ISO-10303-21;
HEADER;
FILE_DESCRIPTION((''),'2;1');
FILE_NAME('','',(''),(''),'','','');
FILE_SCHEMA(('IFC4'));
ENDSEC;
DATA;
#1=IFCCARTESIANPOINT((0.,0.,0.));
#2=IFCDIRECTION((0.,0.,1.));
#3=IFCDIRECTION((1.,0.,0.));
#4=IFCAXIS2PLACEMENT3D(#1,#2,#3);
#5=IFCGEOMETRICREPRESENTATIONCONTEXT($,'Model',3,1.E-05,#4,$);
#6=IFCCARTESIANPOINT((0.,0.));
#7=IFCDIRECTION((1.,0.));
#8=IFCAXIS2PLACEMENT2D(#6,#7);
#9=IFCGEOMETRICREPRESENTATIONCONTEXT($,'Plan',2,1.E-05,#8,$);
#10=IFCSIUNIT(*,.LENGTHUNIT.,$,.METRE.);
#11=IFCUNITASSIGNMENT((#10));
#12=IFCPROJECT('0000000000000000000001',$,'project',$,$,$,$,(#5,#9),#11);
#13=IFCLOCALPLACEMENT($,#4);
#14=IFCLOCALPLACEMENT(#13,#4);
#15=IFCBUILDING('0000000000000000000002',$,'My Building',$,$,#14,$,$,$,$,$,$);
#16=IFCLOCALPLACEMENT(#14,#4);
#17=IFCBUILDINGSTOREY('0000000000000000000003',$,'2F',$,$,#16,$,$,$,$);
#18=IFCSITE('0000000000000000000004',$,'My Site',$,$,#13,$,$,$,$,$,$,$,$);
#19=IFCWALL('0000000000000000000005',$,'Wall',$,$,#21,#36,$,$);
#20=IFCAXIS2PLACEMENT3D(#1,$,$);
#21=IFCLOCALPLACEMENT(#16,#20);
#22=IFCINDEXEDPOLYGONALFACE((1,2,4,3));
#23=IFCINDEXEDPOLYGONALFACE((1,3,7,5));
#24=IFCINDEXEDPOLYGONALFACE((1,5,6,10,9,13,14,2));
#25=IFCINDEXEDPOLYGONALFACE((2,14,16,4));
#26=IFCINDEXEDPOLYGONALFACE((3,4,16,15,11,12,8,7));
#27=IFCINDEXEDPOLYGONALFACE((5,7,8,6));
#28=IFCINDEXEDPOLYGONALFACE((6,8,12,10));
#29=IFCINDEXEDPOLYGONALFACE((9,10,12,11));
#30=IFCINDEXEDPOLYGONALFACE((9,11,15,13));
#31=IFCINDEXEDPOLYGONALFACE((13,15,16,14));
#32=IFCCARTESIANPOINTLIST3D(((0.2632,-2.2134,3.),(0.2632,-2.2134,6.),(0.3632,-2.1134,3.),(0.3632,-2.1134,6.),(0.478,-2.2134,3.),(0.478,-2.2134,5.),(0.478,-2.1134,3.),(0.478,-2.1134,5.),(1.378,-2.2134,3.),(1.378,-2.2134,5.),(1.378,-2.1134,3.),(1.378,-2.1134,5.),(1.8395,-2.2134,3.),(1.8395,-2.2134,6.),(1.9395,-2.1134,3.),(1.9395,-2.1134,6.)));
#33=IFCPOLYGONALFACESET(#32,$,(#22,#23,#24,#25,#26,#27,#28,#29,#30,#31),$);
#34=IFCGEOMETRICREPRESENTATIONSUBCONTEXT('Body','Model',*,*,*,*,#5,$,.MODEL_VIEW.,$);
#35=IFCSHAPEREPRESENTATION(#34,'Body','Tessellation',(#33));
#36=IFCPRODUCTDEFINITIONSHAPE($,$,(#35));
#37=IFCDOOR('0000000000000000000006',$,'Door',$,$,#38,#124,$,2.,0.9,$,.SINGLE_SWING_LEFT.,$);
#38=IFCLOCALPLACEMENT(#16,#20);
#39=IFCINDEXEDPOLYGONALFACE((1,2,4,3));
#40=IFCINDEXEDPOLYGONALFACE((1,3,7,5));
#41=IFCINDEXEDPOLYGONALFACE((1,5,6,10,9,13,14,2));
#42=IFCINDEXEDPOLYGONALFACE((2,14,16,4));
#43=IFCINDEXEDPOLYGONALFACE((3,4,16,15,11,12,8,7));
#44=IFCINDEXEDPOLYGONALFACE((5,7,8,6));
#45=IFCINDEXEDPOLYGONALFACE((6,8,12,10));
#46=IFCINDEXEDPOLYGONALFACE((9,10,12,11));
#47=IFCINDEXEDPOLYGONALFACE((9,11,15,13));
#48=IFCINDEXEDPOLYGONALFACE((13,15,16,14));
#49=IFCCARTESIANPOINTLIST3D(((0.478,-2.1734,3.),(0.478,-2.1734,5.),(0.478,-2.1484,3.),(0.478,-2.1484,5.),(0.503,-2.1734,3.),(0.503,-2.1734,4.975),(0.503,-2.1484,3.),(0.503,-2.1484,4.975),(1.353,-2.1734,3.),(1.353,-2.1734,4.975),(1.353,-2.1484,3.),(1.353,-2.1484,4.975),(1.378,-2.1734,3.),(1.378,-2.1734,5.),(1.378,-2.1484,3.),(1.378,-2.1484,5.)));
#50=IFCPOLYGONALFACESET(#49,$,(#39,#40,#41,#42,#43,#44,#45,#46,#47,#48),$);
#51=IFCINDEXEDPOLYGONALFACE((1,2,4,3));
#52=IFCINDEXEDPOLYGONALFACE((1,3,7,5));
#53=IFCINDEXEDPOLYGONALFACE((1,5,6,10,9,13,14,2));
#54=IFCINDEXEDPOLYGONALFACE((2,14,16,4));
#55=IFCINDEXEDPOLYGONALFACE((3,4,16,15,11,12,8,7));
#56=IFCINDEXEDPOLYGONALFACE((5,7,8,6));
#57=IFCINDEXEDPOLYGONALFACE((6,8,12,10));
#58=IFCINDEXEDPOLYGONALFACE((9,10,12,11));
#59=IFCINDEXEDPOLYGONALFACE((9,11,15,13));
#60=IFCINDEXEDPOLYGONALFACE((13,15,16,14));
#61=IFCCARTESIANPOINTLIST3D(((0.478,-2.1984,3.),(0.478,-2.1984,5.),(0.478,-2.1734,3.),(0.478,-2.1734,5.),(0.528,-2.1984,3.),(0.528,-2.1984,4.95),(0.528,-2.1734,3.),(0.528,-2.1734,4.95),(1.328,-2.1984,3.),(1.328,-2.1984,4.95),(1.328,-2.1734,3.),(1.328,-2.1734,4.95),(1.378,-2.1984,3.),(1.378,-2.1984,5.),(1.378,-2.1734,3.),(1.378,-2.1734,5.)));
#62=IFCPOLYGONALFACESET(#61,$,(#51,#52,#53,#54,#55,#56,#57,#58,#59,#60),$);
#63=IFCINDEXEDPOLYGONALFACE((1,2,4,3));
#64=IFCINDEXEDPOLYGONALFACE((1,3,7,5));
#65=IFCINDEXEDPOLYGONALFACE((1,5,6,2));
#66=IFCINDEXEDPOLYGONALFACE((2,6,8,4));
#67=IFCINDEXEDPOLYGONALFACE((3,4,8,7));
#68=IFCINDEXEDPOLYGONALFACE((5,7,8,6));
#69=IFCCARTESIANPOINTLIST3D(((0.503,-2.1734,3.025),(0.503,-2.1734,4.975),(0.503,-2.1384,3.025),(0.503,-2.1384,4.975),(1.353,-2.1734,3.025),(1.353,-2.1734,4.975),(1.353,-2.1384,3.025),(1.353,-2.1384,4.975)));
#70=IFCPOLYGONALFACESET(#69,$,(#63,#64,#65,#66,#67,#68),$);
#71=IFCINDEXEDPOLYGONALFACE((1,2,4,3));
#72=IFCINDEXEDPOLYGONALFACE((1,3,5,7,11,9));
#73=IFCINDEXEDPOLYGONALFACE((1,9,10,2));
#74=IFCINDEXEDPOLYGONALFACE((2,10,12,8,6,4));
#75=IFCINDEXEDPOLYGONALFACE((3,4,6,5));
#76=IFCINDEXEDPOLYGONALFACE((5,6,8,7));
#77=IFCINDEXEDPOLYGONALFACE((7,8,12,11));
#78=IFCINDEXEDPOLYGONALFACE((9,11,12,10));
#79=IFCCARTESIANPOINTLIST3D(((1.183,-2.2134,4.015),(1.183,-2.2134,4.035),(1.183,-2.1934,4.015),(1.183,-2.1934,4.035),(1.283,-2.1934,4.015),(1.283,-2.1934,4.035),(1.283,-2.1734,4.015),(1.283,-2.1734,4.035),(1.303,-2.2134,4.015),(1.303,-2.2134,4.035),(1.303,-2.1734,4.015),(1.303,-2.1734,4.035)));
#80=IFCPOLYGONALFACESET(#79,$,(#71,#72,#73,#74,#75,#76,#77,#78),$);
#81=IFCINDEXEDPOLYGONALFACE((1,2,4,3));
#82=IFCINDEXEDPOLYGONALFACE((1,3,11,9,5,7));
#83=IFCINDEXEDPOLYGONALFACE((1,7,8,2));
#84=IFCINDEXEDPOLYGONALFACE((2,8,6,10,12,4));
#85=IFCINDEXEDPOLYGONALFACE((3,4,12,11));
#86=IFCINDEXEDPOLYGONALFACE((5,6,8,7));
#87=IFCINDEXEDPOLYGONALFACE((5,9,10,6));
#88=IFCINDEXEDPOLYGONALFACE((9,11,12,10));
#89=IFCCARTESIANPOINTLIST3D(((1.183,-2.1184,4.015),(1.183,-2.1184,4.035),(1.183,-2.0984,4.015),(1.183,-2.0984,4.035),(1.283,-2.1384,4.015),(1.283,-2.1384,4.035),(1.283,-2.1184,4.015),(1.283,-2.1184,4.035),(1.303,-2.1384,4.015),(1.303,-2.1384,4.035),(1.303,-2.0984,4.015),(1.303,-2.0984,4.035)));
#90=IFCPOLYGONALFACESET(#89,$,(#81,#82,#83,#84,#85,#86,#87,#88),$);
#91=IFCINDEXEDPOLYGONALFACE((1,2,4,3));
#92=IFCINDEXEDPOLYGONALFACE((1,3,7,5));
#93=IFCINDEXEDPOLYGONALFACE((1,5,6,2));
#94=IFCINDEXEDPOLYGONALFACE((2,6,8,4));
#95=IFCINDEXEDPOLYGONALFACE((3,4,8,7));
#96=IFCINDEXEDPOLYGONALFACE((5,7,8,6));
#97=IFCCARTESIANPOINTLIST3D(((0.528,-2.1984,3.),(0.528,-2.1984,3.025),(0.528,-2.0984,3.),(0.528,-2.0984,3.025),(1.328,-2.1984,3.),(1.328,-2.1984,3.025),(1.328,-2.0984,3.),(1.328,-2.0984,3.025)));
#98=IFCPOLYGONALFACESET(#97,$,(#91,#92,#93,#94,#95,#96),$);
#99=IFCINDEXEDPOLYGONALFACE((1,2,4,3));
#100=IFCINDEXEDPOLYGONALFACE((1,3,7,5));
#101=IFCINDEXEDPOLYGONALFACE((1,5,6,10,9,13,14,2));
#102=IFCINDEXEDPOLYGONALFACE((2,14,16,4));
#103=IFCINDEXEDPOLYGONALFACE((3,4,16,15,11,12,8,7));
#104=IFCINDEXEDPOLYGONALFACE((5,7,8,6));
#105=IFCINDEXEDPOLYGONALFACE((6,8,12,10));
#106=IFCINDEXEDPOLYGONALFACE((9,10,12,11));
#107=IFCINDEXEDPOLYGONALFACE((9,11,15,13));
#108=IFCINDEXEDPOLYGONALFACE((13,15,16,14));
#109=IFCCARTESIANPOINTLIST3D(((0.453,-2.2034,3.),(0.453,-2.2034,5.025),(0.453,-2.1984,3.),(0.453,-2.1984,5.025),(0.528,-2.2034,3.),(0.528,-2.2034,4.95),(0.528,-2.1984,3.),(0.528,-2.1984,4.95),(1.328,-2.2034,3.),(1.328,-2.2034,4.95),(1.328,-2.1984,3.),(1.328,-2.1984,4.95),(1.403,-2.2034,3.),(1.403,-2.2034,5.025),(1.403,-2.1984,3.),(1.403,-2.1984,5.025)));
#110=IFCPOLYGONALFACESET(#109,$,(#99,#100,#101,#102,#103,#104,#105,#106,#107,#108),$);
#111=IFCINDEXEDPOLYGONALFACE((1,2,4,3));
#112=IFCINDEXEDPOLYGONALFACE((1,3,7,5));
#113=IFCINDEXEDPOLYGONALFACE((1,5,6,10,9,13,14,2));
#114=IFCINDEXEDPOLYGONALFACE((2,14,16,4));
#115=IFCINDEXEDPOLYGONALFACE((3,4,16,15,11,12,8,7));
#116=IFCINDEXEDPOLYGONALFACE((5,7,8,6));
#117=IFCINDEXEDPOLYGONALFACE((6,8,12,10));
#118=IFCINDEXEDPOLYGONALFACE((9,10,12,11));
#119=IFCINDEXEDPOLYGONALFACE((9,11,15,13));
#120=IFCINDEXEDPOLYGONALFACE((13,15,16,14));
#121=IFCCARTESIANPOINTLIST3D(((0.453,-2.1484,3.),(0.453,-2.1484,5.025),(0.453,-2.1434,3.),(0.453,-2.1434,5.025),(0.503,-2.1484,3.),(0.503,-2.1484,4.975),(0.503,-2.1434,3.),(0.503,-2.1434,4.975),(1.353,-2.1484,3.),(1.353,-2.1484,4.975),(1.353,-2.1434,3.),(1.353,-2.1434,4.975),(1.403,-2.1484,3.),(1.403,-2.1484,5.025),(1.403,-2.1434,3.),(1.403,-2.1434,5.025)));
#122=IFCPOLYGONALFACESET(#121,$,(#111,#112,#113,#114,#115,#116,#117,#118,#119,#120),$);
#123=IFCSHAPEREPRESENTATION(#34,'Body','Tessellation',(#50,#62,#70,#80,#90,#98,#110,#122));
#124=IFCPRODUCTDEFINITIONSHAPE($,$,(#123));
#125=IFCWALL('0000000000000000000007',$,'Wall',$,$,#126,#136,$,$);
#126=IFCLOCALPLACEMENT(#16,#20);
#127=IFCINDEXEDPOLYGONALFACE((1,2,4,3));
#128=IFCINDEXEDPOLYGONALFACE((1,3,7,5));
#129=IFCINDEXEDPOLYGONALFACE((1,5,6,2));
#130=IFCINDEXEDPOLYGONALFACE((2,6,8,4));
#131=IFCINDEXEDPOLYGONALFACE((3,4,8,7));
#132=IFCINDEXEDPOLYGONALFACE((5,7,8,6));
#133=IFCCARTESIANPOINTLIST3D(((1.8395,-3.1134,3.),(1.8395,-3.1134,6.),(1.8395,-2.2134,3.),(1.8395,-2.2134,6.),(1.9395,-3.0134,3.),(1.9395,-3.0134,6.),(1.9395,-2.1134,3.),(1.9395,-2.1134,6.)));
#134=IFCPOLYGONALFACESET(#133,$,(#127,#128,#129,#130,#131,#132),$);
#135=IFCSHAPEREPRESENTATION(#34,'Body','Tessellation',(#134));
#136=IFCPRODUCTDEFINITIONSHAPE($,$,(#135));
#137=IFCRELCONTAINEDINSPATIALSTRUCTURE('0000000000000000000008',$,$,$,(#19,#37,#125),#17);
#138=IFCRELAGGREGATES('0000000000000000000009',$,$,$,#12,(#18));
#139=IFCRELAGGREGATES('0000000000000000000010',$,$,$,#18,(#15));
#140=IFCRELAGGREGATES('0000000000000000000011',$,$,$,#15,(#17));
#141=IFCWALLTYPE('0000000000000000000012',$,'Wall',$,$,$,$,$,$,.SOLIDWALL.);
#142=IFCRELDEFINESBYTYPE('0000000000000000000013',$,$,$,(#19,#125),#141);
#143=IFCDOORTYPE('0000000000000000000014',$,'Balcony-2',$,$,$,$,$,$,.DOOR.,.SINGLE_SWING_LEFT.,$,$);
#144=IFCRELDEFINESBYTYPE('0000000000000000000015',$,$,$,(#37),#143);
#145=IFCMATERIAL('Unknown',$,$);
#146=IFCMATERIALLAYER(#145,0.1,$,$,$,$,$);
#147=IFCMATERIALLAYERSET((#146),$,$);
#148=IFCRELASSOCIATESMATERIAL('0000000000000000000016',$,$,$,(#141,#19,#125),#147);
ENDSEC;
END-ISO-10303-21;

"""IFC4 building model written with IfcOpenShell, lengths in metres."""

from ifc_helpers import new_model, entity, si_unit, frame, origin_with_axes, origin_2d_with_axis, place, context, subcontext, project, spatial, line, indexed_curve, outline, extrude, shape, source, transform, mapped, material, layer, layer_set, layer_usage, type_object, type_shapes, element, fill, save


model = new_model("IFC4")

# Units and contexts
model_context = context("Model", 3, precision=1e-05, world=origin_with_axes())
plan_context = context("Plan", 2, precision=1e-05, world=origin_2d_with_axis())
body_context_1 = subcontext(model_context, "Body", "Model", "MODEL_VIEW")
body_context_2 = subcontext(plan_context, "Body", "Plan", "PLAN_VIEW")
ifc_project = project(units=[si_unit("LENGTHUNIT", "METRE")], contexts=[model_context, plan_context])

# Site, building, storey
site_placement = place(None, origin_with_axes())
site = spatial("IfcSite", under=ifc_project, at=site_placement, Name="My Site")
building_placement = place(site_placement, origin_with_axes())
building = spatial("IfcBuilding", under=site, at=building_placement, Name="My Building")
storey_placement = place(building_placement, origin_with_axes())
storey = spatial("IfcBuildingStorey", under=building, at=storey_placement, Name="2F")

# Shared definitions
ifc_material = material(Name="Unknown")
ifc_layer = layer(ifc_material, 0.1)
ifc_layer_set = layer_set([ifc_layer])
wall_type = type_object("IfcWallType", Name="Wall", PredefinedType="SOLIDWALL", material=ifc_layer_set)

# Wall, opening, door
ifc_layer_usage_1 = layer_usage(ifc_layer_set, "AXIS2", "POSITIVE", 0.0)
wall_1_placement = place(storey_placement, frame((0.2632, -2.2134, 3.0), z_axis=(0.0, 0.0, 1.0), x_axis=(1.0, 0.0, 0.0)))
wall_1 = element("IfcWall", 1, at=wall_1_placement, inside=storey, type_object=wall_type, material=ifc_layer_usage_1, Name="Wall", context=body_context_1, shape_type="SweptSolid", body=[
    extrude(outline(indexed_curve([(0.0, 0.0), (0.1, 0.1), (1.6764, 0.1), (1.5764, 0.0)], segments=[line(1, 2, 3, 4, 1)])), origin_with_axes(), (0.0, 0.0, 1.0), 3.0),
])
shared_shape_1 = source(origin_with_axes(), body_context_1, "Body", "SweptSolid", [
    extrude(outline(indexed_curve([(0.0, 0.0), (0.9, 0.0), (0.9, 2.0), (0.0, 2.0)], segments=[line(1, 2, 3, 4, 1)])), frame((0.0, -0.6, 0.0), z_axis=(0.0, -1.0, 0.0), x_axis=(1.0, 0.0, 0.0)), (0.0, 0.0, -1.0), 1.2),
])
opening_1_placement = place(wall_1_placement, frame((0.2148, 0.015, 0.0), z_axis=(0.0, 0.0, 1.0), x_axis=(1.0, 0.0, 0.0)))
opening_1 = element("IfcOpeningElement", 2, at=opening_1_placement, cuts=wall_1, PredefinedType="OPENING", context=body_context_1, shape_type="MappedRepresentation", body=[
    mapped(shared_shape_1, transform((0.0, 0.0, 0.0), x_axis=(1.0, 0.0, 0.0), y_axis=(0.0, 1.0, 0.0), z_axis=(0.0, 0.0, 1.0), scale=1.0)),
])
door_type_1 = type_object("IfcDoorType", Name="Balcony-2", OperationType="SINGLE_SWING_LEFT", PredefinedType="DOOR")
shared_shape_2 = source(origin_with_axes(), body_context_1, "Body", "SweptSolid", [
    extrude(outline(indexed_curve([(0.0, 0.0), (0.0, 2.0), (0.9, 2.0), (0.9, 0.0), (0.875, 0.0), (0.875, 1.975), (0.025, 1.975), (0.025, 0.0)], segments=[line(1, 2, 3, 4, 5, 6, 7, 8, 1)])), frame((0.0, 0.025, 0.0), z_axis=(0.0, -1.0, 0.0), x_axis=(1.0, 0.0, 0.0)), (0.0, 0.0, -1.0), 0.025),
    extrude(outline(indexed_curve([(0.0, 0.0), (0.0, 2.0), (0.9, 2.0), (0.9, 0.0), (0.85, 0.0), (0.85, 1.95), (0.05, 1.95), (0.05, 0.0)], segments=[line(1, 2, 3, 4, 5, 6, 7, 8, 1)])), frame((0.0, 0.0, 0.0), z_axis=(0.0, -1.0, 0.0), x_axis=(1.0, 0.0, 0.0)), (0.0, 0.0, -1.0), 0.025),
    extrude(outline(indexed_curve([(0.0, 0.0), (0.85, 0.0), (0.85, 0.035), (0.0, 0.035)], segments=[line(1, 2, 3, 4, 1)])), frame((0.025, 0.025, 0.025), z_axis=(0.0, 0.0, 1.0), x_axis=(1.0, 0.0, 0.0)), (0.0, 0.0, 1.0), 1.95),
    extrude(outline(indexed_curve([(0.0, 0.0), (0.0, -0.04), (-0.12, -0.04), (-0.12, -0.02), (-0.02, -0.02), (-0.02, 0.0)], segments=[line(1, 2, 3, 4, 5, 6, 1)])), frame((0.825, 0.025, 1.015), z_axis=(0.0, 0.0, 1.0), x_axis=(1.0, 0.0, 0.0)), (0.0, 0.0, 1.0), 0.02),
    extrude(outline(indexed_curve([(0.0, 0.0), (0.0, 0.04), (-0.12, 0.04), (-0.12, 0.02), (-0.02, 0.02), (-0.02, 0.0)], segments=[line(1, 2, 3, 4, 5, 6, 1)])), frame((0.825, 0.06, 1.015), z_axis=(0.0, 0.0, 1.0), x_axis=(1.0, 0.0, 0.0)), (0.0, 0.0, 1.0), 0.02),
    extrude(outline(indexed_curve([(0.0, 0.0), (0.8, 0.0), (0.8, 0.1), (0.0, 0.1)], segments=[line(1, 2, 3, 4, 1)])), frame((0.05, 0.0, 0.0), z_axis=(0.0, 0.0, 1.0), x_axis=(1.0, 0.0, 0.0)), (0.0, 0.0, 1.0), 0.025),
    extrude(outline(indexed_curve([(0.0, 0.0), (0.0, 2.025), (0.95, 2.025), (0.95, 0.0), (0.875, 0.0), (0.875, 1.95), (0.075, 1.95), (0.075, 0.0)], segments=[line(1, 2, 3, 4, 5, 6, 7, 8, 1)])), frame((-0.025, -0.005, 0.0), z_axis=(0.0, -1.0, 0.0), x_axis=(1.0, 0.0, 0.0)), (0.0, 0.0, -1.0), 0.005),
    extrude(outline(indexed_curve([(0.0, 0.0), (0.0, 2.025), (0.95, 2.025), (0.95, 0.0), (0.9, 0.0), (0.9, 1.975), (0.05, 1.975), (0.05, 0.0)], segments=[line(1, 2, 3, 4, 5, 6, 7, 8, 1)])), frame((-0.025, 0.05, 0.0), z_axis=(0.0, -1.0, 0.0), x_axis=(1.0, 0.0, 0.0)), (0.0, 0.0, -1.0), 0.005),
])
shared_shape_3 = source(origin_with_axes(), body_context_2, "Body", "Curve2D", [
    entity("IfcIndexedPolyCurve", entity("IfcCartesianPointList2D", [[0.0, 0.0], [0.0, 0.05], [0.025, 0.05], [0.025, 0.025], [0.05, 0.025], [0.05, 0.0]]), [entity("IfcLineIndex", [1, 2, 3, 4, 5, 6, 1])]),
    entity("IfcIndexedPolyCurve", entity("IfcCartesianPointList2D", [[0.9, 0.0], [0.9, 0.05], [0.875, 0.05], [0.875, 0.025], [0.85, 0.025], [0.85, 0.0]]), [entity("IfcLineIndex", [1, 2, 3, 4, 5, 6, 1])]),
    entity("IfcTrimmedCurve", entity("IfcEllipse", entity("IfcAxis2Placement2D", entity("IfcCartesianPoint", [0.06, 0.05]), entity("IfcDirection", [1.0, 0.0])), 0.815, 0.85), [entity("IfcCartesianPoint", [0.875, 0.05])], [entity("IfcCartesianPoint", [0.06, 0.9])], True, "CARTESIAN"),
    entity("IfcIndexedPolyCurve", entity("IfcCartesianPointList2D", [[0.025, 0.05], [0.06, 0.05], [0.06, 0.9], [0.025, 0.9]]), [entity("IfcLineIndex", [1, 2, 3, 4, 1])]),
])
type_shapes(door_type_1, [shared_shape_2, shared_shape_3])
door_1_placement = place(opening_1_placement, frame((0.0, 0.0, 0.0), z_axis=(0.0, 0.0, 1.0), x_axis=(1.0, 0.0, 0.0)))
door_1 = element("IfcDoor", 3, at=door_1_placement, inside=storey, type_object=door_type_1, Name="Door", OperationType="SINGLE_SWING_LEFT", OverallHeight=2.0, OverallWidth=0.9, shapes=[
    shape(body_context_1, "Body", "MappedRepresentation", [mapped(shared_shape_2, transform((0.0, 0.0, 0.0), x_axis=(1.0, 0.0, 0.0), y_axis=(0.0, 1.0, 0.0), z_axis=(0.0, 0.0, 1.0), scale=1.0))]),
    shape(body_context_2, "Body", "MappedRepresentation", [mapped(shared_shape_3, transform((0.0, 0.0, 0.0), x_axis=(1.0, 0.0, 0.0), y_axis=(0.0, 1.0, 0.0), z_axis=(0.0, 0.0, 1.0), scale=1.0))]),
])
fill(opening_1, door_1)

# Wall
ifc_layer_usage_2 = layer_usage(ifc_layer_set, "AXIS2", "POSITIVE", 0.0)
wall_2_placement = place(storey_placement, frame((1.8395, -2.2134, 3.0), z_axis=(0.0, 0.0, 1.0), x_axis=(0.0, -1.0, 0.0)))
element("IfcWall", 4, at=wall_2_placement, inside=storey, type_object=wall_type, material=ifc_layer_usage_2, Name="Wall", context=body_context_1, shape_type="SweptSolid", body=[
    extrude(outline(indexed_curve([(0.0, 0.0), (-0.1, 0.1), (0.8, 0.1), (0.9, 0.0)], segments=[line(1, 2, 3, 4, 1)])), origin_with_axes(), (0.0, 0.0, 1.0), 3.0),
])

save(model, "model.ifc")
